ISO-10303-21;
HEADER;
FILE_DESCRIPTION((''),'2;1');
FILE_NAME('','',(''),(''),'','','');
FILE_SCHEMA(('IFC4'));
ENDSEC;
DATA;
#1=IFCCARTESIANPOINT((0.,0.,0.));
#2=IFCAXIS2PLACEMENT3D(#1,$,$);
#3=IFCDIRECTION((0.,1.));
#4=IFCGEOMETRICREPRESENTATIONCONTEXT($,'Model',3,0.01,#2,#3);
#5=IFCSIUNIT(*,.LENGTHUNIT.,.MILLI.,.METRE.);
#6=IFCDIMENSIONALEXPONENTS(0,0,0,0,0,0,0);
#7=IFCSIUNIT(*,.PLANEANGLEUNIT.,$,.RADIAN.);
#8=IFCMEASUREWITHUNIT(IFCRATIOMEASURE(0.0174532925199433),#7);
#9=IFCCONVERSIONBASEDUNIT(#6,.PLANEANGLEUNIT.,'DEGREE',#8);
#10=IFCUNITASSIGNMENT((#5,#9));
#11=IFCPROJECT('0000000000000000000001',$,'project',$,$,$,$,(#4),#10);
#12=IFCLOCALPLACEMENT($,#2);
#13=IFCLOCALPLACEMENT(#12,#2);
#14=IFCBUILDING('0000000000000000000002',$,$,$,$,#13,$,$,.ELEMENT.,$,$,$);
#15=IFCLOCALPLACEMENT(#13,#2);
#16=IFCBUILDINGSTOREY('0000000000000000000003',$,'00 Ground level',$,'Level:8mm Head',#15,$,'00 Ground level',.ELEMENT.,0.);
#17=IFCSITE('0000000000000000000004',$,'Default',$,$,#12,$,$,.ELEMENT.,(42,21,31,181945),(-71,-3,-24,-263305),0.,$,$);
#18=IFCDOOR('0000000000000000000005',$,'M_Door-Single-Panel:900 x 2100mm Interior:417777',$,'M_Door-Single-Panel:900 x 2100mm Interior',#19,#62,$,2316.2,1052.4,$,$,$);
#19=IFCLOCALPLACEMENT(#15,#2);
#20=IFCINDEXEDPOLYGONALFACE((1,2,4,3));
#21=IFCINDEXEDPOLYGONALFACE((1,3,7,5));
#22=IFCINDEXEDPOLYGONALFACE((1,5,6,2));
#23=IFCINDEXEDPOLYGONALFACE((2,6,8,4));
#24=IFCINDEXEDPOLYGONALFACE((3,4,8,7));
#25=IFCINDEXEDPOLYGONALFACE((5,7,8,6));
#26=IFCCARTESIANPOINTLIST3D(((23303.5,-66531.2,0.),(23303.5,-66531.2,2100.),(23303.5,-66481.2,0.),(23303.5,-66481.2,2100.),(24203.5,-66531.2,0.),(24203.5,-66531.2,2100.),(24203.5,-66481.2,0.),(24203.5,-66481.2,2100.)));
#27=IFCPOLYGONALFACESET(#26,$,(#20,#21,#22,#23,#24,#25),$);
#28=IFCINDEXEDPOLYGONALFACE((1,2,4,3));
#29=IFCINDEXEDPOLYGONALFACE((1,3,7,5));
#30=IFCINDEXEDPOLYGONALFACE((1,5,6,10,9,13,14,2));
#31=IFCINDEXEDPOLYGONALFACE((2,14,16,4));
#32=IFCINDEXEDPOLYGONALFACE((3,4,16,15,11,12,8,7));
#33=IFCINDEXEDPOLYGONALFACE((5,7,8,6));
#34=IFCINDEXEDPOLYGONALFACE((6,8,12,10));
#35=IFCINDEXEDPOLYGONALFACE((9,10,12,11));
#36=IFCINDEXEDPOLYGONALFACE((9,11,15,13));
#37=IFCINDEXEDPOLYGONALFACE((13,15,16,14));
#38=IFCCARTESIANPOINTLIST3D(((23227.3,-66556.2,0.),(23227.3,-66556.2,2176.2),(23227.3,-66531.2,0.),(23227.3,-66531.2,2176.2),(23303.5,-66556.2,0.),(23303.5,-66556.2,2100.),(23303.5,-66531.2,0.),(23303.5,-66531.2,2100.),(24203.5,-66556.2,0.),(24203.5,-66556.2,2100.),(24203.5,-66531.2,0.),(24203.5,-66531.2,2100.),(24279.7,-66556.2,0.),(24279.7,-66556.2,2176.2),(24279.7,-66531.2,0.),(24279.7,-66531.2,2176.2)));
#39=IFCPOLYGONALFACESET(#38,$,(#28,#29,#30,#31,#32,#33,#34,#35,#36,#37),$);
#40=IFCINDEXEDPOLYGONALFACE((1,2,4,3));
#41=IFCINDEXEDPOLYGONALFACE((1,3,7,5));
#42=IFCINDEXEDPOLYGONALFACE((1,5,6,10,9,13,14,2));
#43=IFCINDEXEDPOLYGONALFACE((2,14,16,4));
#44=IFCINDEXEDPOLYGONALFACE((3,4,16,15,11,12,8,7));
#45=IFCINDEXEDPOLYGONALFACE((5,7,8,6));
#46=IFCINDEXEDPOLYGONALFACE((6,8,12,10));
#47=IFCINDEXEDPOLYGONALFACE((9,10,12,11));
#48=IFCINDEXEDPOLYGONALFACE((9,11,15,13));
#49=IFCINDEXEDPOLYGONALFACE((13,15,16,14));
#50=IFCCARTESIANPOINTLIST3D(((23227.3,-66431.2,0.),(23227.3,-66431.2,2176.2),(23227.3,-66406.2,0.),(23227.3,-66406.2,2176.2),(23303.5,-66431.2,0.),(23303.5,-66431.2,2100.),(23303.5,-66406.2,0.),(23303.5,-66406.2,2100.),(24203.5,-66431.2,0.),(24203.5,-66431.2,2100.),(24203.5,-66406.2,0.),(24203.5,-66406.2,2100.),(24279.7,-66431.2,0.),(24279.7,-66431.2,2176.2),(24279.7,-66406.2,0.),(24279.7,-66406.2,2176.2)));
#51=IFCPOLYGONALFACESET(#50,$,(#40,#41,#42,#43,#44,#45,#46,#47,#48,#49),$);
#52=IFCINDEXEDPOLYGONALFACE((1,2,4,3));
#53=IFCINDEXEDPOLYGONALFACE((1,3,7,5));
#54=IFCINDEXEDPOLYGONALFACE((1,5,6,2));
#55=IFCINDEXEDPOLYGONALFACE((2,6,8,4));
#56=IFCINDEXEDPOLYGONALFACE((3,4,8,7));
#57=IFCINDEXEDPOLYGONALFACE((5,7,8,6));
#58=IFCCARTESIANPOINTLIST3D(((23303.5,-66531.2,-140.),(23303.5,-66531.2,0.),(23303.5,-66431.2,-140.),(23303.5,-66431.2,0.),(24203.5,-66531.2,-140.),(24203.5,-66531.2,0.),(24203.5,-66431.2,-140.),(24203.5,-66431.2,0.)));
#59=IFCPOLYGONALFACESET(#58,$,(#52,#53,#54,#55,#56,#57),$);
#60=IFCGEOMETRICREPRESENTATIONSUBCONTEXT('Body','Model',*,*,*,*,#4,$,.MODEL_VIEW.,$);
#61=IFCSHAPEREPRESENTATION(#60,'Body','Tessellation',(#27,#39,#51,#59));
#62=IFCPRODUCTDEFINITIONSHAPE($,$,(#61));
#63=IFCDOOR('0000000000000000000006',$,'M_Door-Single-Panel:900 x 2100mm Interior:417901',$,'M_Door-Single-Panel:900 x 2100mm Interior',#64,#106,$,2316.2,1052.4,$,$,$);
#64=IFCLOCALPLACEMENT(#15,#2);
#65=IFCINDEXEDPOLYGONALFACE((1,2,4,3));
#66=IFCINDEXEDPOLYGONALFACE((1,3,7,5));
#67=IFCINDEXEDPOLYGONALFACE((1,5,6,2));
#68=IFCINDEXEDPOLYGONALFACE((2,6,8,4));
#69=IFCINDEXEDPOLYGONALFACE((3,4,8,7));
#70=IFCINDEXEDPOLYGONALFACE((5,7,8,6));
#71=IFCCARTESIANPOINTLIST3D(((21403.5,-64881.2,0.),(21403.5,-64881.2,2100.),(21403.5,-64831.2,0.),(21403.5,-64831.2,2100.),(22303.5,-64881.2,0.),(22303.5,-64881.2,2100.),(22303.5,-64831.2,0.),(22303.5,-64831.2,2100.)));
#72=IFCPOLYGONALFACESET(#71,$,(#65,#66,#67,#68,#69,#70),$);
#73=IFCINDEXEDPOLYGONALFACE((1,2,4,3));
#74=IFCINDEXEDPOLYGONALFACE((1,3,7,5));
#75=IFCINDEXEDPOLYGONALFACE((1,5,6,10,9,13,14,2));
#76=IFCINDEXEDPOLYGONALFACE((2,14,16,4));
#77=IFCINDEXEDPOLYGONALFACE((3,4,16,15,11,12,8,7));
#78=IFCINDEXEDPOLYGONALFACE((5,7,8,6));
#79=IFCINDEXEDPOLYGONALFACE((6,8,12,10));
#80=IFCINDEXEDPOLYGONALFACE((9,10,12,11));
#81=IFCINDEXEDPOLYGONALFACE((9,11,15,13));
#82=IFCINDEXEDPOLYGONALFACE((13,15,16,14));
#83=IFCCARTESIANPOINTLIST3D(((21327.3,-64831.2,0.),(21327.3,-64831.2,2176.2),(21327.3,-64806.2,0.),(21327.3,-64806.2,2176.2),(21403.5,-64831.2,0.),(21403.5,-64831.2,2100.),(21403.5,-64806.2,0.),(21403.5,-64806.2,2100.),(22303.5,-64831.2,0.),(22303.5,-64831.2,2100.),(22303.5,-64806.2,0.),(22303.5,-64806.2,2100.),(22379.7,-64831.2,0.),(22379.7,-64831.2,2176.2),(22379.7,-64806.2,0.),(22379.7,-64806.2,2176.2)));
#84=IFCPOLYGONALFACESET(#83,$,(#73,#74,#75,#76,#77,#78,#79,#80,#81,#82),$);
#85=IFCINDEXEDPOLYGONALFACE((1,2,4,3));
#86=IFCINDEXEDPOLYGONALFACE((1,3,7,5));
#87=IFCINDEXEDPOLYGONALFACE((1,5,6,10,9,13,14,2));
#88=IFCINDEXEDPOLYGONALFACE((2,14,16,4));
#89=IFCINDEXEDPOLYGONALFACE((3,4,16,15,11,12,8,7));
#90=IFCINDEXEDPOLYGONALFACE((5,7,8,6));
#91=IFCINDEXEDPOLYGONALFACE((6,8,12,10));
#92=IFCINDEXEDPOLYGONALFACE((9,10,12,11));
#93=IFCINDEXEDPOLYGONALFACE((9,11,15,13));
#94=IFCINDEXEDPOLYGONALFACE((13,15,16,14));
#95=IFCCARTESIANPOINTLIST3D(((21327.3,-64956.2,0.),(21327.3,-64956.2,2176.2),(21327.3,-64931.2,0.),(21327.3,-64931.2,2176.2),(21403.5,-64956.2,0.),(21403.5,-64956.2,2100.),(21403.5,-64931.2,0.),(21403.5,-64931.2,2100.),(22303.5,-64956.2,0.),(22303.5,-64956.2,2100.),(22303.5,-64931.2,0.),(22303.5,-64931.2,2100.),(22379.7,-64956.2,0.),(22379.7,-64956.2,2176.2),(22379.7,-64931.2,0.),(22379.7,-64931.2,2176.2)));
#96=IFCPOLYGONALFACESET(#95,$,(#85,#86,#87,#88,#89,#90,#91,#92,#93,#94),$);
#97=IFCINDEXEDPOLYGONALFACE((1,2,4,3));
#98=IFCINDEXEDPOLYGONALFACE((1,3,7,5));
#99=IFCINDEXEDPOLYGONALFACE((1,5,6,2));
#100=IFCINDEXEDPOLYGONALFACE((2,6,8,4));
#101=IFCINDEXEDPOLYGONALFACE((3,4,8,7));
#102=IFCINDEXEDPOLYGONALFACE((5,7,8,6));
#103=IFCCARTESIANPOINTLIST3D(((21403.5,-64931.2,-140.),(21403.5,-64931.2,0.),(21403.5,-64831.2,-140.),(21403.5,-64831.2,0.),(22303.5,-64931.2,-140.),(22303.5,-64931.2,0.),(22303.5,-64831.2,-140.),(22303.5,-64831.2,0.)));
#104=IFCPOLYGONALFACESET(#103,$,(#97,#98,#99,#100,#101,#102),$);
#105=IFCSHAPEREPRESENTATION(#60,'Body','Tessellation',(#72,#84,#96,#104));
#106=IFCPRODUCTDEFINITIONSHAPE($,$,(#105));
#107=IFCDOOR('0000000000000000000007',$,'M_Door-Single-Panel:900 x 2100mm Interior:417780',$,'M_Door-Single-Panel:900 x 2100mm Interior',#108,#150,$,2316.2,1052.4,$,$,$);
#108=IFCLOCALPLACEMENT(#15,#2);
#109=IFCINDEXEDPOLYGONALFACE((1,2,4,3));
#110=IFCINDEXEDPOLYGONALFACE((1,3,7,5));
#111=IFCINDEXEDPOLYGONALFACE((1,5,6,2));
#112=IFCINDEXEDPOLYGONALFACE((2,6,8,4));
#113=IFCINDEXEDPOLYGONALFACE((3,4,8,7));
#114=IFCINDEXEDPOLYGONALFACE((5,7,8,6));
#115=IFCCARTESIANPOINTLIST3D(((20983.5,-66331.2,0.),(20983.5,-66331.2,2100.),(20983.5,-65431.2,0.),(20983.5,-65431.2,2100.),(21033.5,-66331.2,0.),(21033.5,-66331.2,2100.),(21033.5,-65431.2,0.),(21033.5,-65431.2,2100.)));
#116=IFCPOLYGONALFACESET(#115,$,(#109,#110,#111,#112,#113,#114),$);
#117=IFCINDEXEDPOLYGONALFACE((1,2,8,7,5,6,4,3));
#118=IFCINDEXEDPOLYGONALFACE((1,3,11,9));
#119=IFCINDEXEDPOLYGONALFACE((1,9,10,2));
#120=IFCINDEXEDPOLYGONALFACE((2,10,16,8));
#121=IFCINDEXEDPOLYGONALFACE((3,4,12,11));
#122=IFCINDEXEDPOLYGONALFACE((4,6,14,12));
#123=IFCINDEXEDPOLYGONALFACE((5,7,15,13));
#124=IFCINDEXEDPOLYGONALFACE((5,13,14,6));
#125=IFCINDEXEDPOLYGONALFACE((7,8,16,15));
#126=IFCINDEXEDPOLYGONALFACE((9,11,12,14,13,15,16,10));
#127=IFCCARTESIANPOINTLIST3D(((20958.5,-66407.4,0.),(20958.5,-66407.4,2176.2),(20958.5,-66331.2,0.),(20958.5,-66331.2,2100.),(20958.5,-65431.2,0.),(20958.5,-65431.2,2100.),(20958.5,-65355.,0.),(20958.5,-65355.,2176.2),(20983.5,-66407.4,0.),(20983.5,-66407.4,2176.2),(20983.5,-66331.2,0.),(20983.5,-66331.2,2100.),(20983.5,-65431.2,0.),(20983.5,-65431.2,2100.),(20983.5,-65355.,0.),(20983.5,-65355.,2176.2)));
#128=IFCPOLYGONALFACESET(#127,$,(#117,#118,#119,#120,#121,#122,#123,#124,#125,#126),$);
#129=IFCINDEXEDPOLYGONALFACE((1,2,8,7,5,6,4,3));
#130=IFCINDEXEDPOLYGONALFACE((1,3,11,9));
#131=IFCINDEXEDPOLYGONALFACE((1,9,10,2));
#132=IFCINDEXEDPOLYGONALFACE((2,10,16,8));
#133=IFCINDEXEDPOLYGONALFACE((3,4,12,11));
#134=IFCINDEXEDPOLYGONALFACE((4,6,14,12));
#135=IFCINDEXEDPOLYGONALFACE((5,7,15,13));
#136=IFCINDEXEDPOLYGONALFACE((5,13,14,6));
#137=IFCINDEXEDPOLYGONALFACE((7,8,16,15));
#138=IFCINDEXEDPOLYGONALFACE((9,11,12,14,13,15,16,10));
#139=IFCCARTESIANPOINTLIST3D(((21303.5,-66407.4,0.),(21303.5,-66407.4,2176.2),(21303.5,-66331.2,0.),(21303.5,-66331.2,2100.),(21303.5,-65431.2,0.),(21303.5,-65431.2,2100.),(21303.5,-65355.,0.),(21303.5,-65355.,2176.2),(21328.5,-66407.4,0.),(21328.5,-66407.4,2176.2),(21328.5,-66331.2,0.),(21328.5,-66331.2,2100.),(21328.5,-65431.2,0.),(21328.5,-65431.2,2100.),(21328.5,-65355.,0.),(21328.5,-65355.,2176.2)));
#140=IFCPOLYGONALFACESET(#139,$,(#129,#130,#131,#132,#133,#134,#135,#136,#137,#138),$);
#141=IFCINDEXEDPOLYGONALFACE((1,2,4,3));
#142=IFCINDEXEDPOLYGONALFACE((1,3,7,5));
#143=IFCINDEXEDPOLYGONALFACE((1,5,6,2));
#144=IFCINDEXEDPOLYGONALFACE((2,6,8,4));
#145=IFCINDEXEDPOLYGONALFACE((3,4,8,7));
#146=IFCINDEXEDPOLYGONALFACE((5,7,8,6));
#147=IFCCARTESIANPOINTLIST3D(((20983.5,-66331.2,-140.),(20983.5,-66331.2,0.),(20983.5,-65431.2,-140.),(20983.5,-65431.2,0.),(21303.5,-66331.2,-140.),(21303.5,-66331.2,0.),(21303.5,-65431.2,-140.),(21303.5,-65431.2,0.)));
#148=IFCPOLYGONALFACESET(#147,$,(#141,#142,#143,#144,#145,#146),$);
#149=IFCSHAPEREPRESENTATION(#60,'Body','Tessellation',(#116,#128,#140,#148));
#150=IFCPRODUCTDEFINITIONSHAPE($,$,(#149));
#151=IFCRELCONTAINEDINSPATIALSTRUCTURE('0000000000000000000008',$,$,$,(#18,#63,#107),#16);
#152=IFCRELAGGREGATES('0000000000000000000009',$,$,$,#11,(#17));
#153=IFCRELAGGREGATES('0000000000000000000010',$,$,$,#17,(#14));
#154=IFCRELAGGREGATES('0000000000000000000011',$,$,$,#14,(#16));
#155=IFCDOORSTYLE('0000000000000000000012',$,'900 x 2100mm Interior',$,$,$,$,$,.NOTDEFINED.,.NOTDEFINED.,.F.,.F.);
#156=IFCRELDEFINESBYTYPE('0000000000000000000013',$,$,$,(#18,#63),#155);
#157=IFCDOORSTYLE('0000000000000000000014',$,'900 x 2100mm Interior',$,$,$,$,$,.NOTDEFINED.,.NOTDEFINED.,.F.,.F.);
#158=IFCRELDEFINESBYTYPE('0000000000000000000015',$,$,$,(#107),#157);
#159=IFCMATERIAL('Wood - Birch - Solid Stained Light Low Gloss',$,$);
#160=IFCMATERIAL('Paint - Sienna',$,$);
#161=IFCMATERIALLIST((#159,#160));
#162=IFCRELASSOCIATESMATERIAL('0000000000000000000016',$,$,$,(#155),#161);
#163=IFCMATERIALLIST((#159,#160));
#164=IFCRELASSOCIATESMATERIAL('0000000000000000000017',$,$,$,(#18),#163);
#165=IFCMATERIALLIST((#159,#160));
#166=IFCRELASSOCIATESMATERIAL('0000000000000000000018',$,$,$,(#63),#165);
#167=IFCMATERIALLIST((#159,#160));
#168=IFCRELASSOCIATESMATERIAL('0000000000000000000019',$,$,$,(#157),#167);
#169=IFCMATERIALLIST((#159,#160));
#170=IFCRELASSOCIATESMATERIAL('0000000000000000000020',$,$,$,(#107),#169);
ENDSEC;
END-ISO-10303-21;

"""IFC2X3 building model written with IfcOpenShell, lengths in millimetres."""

from ifc_helpers import new_model, entity, si_unit, converted_unit, direction, frame, origin, origin_2d_with_axis, place, context, subcontext, project, spatial, polyline, rectangle, outline, extrude, source, transform, mapped, material, material_list, type_object, type_shapes, element, save


model = new_model("IFC2X3")

# Units and contexts
model_context = context("Model", 3, precision=0.01, world=origin(), true_north=direction((0.0, 1.0)))
body_context = subcontext(model_context, "Body", "Model", "MODEL_VIEW")
ifc_project = project(units=[si_unit("LENGTHUNIT", "METRE", prefix="MILLI"), converted_unit("PLANEANGLEUNIT", "DEGREE", entity("IfcRatioMeasure", 0.0174532925199433), si_unit("PLANEANGLEUNIT", "RADIAN"), dimensions=[0, 0, 0, 0, 0, 0, 0])], contexts=[model_context])

# Site, building, storey
site_placement = place(None, origin())
site = spatial("IfcSite", under=ifc_project, at=site_placement, Name="Default", CompositionType="ELEMENT", RefLatitude=(42, 21, 31, 181945), RefLongitude=(-71, -3, -24, -263305), RefElevation=0.0)
building_placement = place(site_placement, origin())
building = spatial("IfcBuilding", under=site, at=building_placement, CompositionType="ELEMENT")
storey_placement = place(building_placement, origin())
storey = spatial("IfcBuildingStorey", under=building, at=storey_placement, Name="00 Ground level", ObjectType="Level:8mm Head", LongName="00 Ground level", CompositionType="ELEMENT", Elevation=0.0)

# Doors
ifc_material_1 = material(Name="Wood - Birch - Solid Stained Light Low Gloss")
ifc_material_2 = material(Name="Paint - Sienna")
ifc_material_list_1 = material_list([ifc_material_1, ifc_material_2])
ifc_material_list_2 = material_list([ifc_material_1, ifc_material_2])
door_style_1 = type_object("IfcDoorStyle", Name="900 x 2100mm Interior", ConstructionType="NOTDEFINED", OperationType="NOTDEFINED", ParameterTakesPrecedence=False, Sizeable=False, material=ifc_material_list_2)
shared_shape_1 = source(origin(), body_context, "Body", "SweptSolid", [
    extrude(rectangle(XDim=900.0, YDim=50.0, at=origin_2d_with_axis()), frame((450.0, 75.0, 140.0)), (0.0, 0.0, 1.0), 2100.0),
    extrude(outline(polyline([(-526.2, -1107.2), (526.2, -1107.2), (526.2, 1069.0), (450.0, 1069.0), (450.0, -1031.0), (-450.0, -1031.0), (-450.0, 1069.0), (-526.2, 1069.0), (-526.2, -1107.2)])), frame((450.0, 125.0, 1209.0), z_axis=(0.0, -1.0, 0.0), x_axis=(-1.0, 0.0, 0.0)), (0.0, 0.0, 1.0), 25.0),
    extrude(outline(polyline([(-1107.2, -526.2), (1069.0, -526.2), (1069.0, -450.0), (-1031.0, -450.0), (-1031.0, 450.0), (1069.0, 450.0), (1069.0, 526.2), (-1107.2, 526.2), (-1107.2, -526.2)])), frame((450.0, 0.0, 1209.0), z_axis=(0.0, -1.0, 0.0), x_axis=(0.0, 0.0, -1.0)), (0.0, 0.0, 1.0), 25.0),
    extrude(rectangle(XDim=100.0, YDim=900.0, at=origin_2d_with_axis()), frame((450.0, 50.0, 0.0), z_axis=(0.0, 0.0, 1.0), x_axis=(0.0, -1.0, 0.0)), (0.0, 0.0, 1.0), 140.0),
])
type_shapes(door_style_1, [shared_shape_1])
door_1_placement = place(storey_placement, frame((24203.5, -66431.2, -140.0), z_axis=(0.0, 0.0, 1.0), x_axis=(-1.0, 0.0, 0.0)))
element("IfcDoor", 1, at=door_1_placement, inside=storey, type_object=door_style_1, material=ifc_material_list_1, Name="M_Door-Single-Panel:900 x 2100mm Interior:417777", ObjectType="M_Door-Single-Panel:900 x 2100mm Interior", OverallHeight=2316.2, OverallWidth=1052.4, context=body_context, shape_type="MappedRepresentation", body=[
    mapped(shared_shape_1, transform((0.0, 0.0, 0.0), scale=1.0)),
])
ifc_material_list_3 = material_list([ifc_material_1, ifc_material_2])
door_2_placement = place(storey_placement, frame((21403.5, -64931.2, -140.0)))
element("IfcDoor", 2, at=door_2_placement, inside=storey, type_object=door_style_1, material=ifc_material_list_3, Name="M_Door-Single-Panel:900 x 2100mm Interior:417901", ObjectType="M_Door-Single-Panel:900 x 2100mm Interior", OverallHeight=2316.2, OverallWidth=1052.4, context=body_context, shape_type="MappedRepresentation", body=[
    mapped(shared_shape_1, transform((0.0, 0.0, 0.0), scale=1.0)),
])
ifc_material_list_4 = material_list([ifc_material_1, ifc_material_2])
ifc_material_list_5 = material_list([ifc_material_1, ifc_material_2])
door_style_2 = type_object("IfcDoorStyle", Name="900 x 2100mm Interior", ConstructionType="NOTDEFINED", OperationType="NOTDEFINED", ParameterTakesPrecedence=False, Sizeable=False, material=ifc_material_list_5)
shared_shape_2 = source(origin(), body_context, "Body", "SweptSolid", [
    extrude(rectangle(XDim=900.0, YDim=50.0, at=origin_2d_with_axis()), frame((450.0, 295.0, 140.0)), (0.0, 0.0, 1.0), 2100.0),
    extrude(outline(polyline([(-526.2, -1107.2), (526.2, -1107.2), (526.2, 1069.0), (450.0, 1069.0), (450.0, -1031.0), (-450.0, -1031.0), (-450.0, 1069.0), (-526.2, 1069.0), (-526.2, -1107.2)])), frame((450.0, 345.0, 1209.0), z_axis=(0.0, -1.0, 0.0), x_axis=(-1.0, 0.0, 0.0)), (0.0, 0.0, 1.0), 25.0),
    extrude(outline(polyline([(-1107.2, -526.2), (1069.0, -526.2), (1069.0, -450.0), (-1031.0, -450.0), (-1031.0, 450.0), (1069.0, 450.0), (1069.0, 526.2), (-1107.2, 526.2), (-1107.2, -526.2)])), frame((450.0, 0.0, 1209.0), z_axis=(0.0, -1.0, 0.0), x_axis=(0.0, 0.0, -1.0)), (0.0, 0.0, 1.0), 25.0),
    extrude(rectangle(XDim=320.0, YDim=900.0, at=origin_2d_with_axis()), frame((450.0, 160.0, 0.0), z_axis=(0.0, 0.0, 1.0), x_axis=(0.0, -1.0, 0.0)), (0.0, 0.0, 1.0), 140.0),
])
type_shapes(door_style_2, [shared_shape_2])
door_3_placement = place(storey_placement, frame((21303.5, -66331.2, -140.0), z_axis=(0.0, 0.0, 1.0), x_axis=(0.0, 1.0, 0.0)))
element("IfcDoor", 3, at=door_3_placement, inside=storey, type_object=door_style_2, material=ifc_material_list_4, Name="M_Door-Single-Panel:900 x 2100mm Interior:417780", ObjectType="M_Door-Single-Panel:900 x 2100mm Interior", OverallHeight=2316.2, OverallWidth=1052.4, context=body_context, shape_type="MappedRepresentation", body=[
    mapped(shared_shape_2, transform((0.0, 0.0, 0.0), scale=1.0)),
])

save(model, "model.ifc")
